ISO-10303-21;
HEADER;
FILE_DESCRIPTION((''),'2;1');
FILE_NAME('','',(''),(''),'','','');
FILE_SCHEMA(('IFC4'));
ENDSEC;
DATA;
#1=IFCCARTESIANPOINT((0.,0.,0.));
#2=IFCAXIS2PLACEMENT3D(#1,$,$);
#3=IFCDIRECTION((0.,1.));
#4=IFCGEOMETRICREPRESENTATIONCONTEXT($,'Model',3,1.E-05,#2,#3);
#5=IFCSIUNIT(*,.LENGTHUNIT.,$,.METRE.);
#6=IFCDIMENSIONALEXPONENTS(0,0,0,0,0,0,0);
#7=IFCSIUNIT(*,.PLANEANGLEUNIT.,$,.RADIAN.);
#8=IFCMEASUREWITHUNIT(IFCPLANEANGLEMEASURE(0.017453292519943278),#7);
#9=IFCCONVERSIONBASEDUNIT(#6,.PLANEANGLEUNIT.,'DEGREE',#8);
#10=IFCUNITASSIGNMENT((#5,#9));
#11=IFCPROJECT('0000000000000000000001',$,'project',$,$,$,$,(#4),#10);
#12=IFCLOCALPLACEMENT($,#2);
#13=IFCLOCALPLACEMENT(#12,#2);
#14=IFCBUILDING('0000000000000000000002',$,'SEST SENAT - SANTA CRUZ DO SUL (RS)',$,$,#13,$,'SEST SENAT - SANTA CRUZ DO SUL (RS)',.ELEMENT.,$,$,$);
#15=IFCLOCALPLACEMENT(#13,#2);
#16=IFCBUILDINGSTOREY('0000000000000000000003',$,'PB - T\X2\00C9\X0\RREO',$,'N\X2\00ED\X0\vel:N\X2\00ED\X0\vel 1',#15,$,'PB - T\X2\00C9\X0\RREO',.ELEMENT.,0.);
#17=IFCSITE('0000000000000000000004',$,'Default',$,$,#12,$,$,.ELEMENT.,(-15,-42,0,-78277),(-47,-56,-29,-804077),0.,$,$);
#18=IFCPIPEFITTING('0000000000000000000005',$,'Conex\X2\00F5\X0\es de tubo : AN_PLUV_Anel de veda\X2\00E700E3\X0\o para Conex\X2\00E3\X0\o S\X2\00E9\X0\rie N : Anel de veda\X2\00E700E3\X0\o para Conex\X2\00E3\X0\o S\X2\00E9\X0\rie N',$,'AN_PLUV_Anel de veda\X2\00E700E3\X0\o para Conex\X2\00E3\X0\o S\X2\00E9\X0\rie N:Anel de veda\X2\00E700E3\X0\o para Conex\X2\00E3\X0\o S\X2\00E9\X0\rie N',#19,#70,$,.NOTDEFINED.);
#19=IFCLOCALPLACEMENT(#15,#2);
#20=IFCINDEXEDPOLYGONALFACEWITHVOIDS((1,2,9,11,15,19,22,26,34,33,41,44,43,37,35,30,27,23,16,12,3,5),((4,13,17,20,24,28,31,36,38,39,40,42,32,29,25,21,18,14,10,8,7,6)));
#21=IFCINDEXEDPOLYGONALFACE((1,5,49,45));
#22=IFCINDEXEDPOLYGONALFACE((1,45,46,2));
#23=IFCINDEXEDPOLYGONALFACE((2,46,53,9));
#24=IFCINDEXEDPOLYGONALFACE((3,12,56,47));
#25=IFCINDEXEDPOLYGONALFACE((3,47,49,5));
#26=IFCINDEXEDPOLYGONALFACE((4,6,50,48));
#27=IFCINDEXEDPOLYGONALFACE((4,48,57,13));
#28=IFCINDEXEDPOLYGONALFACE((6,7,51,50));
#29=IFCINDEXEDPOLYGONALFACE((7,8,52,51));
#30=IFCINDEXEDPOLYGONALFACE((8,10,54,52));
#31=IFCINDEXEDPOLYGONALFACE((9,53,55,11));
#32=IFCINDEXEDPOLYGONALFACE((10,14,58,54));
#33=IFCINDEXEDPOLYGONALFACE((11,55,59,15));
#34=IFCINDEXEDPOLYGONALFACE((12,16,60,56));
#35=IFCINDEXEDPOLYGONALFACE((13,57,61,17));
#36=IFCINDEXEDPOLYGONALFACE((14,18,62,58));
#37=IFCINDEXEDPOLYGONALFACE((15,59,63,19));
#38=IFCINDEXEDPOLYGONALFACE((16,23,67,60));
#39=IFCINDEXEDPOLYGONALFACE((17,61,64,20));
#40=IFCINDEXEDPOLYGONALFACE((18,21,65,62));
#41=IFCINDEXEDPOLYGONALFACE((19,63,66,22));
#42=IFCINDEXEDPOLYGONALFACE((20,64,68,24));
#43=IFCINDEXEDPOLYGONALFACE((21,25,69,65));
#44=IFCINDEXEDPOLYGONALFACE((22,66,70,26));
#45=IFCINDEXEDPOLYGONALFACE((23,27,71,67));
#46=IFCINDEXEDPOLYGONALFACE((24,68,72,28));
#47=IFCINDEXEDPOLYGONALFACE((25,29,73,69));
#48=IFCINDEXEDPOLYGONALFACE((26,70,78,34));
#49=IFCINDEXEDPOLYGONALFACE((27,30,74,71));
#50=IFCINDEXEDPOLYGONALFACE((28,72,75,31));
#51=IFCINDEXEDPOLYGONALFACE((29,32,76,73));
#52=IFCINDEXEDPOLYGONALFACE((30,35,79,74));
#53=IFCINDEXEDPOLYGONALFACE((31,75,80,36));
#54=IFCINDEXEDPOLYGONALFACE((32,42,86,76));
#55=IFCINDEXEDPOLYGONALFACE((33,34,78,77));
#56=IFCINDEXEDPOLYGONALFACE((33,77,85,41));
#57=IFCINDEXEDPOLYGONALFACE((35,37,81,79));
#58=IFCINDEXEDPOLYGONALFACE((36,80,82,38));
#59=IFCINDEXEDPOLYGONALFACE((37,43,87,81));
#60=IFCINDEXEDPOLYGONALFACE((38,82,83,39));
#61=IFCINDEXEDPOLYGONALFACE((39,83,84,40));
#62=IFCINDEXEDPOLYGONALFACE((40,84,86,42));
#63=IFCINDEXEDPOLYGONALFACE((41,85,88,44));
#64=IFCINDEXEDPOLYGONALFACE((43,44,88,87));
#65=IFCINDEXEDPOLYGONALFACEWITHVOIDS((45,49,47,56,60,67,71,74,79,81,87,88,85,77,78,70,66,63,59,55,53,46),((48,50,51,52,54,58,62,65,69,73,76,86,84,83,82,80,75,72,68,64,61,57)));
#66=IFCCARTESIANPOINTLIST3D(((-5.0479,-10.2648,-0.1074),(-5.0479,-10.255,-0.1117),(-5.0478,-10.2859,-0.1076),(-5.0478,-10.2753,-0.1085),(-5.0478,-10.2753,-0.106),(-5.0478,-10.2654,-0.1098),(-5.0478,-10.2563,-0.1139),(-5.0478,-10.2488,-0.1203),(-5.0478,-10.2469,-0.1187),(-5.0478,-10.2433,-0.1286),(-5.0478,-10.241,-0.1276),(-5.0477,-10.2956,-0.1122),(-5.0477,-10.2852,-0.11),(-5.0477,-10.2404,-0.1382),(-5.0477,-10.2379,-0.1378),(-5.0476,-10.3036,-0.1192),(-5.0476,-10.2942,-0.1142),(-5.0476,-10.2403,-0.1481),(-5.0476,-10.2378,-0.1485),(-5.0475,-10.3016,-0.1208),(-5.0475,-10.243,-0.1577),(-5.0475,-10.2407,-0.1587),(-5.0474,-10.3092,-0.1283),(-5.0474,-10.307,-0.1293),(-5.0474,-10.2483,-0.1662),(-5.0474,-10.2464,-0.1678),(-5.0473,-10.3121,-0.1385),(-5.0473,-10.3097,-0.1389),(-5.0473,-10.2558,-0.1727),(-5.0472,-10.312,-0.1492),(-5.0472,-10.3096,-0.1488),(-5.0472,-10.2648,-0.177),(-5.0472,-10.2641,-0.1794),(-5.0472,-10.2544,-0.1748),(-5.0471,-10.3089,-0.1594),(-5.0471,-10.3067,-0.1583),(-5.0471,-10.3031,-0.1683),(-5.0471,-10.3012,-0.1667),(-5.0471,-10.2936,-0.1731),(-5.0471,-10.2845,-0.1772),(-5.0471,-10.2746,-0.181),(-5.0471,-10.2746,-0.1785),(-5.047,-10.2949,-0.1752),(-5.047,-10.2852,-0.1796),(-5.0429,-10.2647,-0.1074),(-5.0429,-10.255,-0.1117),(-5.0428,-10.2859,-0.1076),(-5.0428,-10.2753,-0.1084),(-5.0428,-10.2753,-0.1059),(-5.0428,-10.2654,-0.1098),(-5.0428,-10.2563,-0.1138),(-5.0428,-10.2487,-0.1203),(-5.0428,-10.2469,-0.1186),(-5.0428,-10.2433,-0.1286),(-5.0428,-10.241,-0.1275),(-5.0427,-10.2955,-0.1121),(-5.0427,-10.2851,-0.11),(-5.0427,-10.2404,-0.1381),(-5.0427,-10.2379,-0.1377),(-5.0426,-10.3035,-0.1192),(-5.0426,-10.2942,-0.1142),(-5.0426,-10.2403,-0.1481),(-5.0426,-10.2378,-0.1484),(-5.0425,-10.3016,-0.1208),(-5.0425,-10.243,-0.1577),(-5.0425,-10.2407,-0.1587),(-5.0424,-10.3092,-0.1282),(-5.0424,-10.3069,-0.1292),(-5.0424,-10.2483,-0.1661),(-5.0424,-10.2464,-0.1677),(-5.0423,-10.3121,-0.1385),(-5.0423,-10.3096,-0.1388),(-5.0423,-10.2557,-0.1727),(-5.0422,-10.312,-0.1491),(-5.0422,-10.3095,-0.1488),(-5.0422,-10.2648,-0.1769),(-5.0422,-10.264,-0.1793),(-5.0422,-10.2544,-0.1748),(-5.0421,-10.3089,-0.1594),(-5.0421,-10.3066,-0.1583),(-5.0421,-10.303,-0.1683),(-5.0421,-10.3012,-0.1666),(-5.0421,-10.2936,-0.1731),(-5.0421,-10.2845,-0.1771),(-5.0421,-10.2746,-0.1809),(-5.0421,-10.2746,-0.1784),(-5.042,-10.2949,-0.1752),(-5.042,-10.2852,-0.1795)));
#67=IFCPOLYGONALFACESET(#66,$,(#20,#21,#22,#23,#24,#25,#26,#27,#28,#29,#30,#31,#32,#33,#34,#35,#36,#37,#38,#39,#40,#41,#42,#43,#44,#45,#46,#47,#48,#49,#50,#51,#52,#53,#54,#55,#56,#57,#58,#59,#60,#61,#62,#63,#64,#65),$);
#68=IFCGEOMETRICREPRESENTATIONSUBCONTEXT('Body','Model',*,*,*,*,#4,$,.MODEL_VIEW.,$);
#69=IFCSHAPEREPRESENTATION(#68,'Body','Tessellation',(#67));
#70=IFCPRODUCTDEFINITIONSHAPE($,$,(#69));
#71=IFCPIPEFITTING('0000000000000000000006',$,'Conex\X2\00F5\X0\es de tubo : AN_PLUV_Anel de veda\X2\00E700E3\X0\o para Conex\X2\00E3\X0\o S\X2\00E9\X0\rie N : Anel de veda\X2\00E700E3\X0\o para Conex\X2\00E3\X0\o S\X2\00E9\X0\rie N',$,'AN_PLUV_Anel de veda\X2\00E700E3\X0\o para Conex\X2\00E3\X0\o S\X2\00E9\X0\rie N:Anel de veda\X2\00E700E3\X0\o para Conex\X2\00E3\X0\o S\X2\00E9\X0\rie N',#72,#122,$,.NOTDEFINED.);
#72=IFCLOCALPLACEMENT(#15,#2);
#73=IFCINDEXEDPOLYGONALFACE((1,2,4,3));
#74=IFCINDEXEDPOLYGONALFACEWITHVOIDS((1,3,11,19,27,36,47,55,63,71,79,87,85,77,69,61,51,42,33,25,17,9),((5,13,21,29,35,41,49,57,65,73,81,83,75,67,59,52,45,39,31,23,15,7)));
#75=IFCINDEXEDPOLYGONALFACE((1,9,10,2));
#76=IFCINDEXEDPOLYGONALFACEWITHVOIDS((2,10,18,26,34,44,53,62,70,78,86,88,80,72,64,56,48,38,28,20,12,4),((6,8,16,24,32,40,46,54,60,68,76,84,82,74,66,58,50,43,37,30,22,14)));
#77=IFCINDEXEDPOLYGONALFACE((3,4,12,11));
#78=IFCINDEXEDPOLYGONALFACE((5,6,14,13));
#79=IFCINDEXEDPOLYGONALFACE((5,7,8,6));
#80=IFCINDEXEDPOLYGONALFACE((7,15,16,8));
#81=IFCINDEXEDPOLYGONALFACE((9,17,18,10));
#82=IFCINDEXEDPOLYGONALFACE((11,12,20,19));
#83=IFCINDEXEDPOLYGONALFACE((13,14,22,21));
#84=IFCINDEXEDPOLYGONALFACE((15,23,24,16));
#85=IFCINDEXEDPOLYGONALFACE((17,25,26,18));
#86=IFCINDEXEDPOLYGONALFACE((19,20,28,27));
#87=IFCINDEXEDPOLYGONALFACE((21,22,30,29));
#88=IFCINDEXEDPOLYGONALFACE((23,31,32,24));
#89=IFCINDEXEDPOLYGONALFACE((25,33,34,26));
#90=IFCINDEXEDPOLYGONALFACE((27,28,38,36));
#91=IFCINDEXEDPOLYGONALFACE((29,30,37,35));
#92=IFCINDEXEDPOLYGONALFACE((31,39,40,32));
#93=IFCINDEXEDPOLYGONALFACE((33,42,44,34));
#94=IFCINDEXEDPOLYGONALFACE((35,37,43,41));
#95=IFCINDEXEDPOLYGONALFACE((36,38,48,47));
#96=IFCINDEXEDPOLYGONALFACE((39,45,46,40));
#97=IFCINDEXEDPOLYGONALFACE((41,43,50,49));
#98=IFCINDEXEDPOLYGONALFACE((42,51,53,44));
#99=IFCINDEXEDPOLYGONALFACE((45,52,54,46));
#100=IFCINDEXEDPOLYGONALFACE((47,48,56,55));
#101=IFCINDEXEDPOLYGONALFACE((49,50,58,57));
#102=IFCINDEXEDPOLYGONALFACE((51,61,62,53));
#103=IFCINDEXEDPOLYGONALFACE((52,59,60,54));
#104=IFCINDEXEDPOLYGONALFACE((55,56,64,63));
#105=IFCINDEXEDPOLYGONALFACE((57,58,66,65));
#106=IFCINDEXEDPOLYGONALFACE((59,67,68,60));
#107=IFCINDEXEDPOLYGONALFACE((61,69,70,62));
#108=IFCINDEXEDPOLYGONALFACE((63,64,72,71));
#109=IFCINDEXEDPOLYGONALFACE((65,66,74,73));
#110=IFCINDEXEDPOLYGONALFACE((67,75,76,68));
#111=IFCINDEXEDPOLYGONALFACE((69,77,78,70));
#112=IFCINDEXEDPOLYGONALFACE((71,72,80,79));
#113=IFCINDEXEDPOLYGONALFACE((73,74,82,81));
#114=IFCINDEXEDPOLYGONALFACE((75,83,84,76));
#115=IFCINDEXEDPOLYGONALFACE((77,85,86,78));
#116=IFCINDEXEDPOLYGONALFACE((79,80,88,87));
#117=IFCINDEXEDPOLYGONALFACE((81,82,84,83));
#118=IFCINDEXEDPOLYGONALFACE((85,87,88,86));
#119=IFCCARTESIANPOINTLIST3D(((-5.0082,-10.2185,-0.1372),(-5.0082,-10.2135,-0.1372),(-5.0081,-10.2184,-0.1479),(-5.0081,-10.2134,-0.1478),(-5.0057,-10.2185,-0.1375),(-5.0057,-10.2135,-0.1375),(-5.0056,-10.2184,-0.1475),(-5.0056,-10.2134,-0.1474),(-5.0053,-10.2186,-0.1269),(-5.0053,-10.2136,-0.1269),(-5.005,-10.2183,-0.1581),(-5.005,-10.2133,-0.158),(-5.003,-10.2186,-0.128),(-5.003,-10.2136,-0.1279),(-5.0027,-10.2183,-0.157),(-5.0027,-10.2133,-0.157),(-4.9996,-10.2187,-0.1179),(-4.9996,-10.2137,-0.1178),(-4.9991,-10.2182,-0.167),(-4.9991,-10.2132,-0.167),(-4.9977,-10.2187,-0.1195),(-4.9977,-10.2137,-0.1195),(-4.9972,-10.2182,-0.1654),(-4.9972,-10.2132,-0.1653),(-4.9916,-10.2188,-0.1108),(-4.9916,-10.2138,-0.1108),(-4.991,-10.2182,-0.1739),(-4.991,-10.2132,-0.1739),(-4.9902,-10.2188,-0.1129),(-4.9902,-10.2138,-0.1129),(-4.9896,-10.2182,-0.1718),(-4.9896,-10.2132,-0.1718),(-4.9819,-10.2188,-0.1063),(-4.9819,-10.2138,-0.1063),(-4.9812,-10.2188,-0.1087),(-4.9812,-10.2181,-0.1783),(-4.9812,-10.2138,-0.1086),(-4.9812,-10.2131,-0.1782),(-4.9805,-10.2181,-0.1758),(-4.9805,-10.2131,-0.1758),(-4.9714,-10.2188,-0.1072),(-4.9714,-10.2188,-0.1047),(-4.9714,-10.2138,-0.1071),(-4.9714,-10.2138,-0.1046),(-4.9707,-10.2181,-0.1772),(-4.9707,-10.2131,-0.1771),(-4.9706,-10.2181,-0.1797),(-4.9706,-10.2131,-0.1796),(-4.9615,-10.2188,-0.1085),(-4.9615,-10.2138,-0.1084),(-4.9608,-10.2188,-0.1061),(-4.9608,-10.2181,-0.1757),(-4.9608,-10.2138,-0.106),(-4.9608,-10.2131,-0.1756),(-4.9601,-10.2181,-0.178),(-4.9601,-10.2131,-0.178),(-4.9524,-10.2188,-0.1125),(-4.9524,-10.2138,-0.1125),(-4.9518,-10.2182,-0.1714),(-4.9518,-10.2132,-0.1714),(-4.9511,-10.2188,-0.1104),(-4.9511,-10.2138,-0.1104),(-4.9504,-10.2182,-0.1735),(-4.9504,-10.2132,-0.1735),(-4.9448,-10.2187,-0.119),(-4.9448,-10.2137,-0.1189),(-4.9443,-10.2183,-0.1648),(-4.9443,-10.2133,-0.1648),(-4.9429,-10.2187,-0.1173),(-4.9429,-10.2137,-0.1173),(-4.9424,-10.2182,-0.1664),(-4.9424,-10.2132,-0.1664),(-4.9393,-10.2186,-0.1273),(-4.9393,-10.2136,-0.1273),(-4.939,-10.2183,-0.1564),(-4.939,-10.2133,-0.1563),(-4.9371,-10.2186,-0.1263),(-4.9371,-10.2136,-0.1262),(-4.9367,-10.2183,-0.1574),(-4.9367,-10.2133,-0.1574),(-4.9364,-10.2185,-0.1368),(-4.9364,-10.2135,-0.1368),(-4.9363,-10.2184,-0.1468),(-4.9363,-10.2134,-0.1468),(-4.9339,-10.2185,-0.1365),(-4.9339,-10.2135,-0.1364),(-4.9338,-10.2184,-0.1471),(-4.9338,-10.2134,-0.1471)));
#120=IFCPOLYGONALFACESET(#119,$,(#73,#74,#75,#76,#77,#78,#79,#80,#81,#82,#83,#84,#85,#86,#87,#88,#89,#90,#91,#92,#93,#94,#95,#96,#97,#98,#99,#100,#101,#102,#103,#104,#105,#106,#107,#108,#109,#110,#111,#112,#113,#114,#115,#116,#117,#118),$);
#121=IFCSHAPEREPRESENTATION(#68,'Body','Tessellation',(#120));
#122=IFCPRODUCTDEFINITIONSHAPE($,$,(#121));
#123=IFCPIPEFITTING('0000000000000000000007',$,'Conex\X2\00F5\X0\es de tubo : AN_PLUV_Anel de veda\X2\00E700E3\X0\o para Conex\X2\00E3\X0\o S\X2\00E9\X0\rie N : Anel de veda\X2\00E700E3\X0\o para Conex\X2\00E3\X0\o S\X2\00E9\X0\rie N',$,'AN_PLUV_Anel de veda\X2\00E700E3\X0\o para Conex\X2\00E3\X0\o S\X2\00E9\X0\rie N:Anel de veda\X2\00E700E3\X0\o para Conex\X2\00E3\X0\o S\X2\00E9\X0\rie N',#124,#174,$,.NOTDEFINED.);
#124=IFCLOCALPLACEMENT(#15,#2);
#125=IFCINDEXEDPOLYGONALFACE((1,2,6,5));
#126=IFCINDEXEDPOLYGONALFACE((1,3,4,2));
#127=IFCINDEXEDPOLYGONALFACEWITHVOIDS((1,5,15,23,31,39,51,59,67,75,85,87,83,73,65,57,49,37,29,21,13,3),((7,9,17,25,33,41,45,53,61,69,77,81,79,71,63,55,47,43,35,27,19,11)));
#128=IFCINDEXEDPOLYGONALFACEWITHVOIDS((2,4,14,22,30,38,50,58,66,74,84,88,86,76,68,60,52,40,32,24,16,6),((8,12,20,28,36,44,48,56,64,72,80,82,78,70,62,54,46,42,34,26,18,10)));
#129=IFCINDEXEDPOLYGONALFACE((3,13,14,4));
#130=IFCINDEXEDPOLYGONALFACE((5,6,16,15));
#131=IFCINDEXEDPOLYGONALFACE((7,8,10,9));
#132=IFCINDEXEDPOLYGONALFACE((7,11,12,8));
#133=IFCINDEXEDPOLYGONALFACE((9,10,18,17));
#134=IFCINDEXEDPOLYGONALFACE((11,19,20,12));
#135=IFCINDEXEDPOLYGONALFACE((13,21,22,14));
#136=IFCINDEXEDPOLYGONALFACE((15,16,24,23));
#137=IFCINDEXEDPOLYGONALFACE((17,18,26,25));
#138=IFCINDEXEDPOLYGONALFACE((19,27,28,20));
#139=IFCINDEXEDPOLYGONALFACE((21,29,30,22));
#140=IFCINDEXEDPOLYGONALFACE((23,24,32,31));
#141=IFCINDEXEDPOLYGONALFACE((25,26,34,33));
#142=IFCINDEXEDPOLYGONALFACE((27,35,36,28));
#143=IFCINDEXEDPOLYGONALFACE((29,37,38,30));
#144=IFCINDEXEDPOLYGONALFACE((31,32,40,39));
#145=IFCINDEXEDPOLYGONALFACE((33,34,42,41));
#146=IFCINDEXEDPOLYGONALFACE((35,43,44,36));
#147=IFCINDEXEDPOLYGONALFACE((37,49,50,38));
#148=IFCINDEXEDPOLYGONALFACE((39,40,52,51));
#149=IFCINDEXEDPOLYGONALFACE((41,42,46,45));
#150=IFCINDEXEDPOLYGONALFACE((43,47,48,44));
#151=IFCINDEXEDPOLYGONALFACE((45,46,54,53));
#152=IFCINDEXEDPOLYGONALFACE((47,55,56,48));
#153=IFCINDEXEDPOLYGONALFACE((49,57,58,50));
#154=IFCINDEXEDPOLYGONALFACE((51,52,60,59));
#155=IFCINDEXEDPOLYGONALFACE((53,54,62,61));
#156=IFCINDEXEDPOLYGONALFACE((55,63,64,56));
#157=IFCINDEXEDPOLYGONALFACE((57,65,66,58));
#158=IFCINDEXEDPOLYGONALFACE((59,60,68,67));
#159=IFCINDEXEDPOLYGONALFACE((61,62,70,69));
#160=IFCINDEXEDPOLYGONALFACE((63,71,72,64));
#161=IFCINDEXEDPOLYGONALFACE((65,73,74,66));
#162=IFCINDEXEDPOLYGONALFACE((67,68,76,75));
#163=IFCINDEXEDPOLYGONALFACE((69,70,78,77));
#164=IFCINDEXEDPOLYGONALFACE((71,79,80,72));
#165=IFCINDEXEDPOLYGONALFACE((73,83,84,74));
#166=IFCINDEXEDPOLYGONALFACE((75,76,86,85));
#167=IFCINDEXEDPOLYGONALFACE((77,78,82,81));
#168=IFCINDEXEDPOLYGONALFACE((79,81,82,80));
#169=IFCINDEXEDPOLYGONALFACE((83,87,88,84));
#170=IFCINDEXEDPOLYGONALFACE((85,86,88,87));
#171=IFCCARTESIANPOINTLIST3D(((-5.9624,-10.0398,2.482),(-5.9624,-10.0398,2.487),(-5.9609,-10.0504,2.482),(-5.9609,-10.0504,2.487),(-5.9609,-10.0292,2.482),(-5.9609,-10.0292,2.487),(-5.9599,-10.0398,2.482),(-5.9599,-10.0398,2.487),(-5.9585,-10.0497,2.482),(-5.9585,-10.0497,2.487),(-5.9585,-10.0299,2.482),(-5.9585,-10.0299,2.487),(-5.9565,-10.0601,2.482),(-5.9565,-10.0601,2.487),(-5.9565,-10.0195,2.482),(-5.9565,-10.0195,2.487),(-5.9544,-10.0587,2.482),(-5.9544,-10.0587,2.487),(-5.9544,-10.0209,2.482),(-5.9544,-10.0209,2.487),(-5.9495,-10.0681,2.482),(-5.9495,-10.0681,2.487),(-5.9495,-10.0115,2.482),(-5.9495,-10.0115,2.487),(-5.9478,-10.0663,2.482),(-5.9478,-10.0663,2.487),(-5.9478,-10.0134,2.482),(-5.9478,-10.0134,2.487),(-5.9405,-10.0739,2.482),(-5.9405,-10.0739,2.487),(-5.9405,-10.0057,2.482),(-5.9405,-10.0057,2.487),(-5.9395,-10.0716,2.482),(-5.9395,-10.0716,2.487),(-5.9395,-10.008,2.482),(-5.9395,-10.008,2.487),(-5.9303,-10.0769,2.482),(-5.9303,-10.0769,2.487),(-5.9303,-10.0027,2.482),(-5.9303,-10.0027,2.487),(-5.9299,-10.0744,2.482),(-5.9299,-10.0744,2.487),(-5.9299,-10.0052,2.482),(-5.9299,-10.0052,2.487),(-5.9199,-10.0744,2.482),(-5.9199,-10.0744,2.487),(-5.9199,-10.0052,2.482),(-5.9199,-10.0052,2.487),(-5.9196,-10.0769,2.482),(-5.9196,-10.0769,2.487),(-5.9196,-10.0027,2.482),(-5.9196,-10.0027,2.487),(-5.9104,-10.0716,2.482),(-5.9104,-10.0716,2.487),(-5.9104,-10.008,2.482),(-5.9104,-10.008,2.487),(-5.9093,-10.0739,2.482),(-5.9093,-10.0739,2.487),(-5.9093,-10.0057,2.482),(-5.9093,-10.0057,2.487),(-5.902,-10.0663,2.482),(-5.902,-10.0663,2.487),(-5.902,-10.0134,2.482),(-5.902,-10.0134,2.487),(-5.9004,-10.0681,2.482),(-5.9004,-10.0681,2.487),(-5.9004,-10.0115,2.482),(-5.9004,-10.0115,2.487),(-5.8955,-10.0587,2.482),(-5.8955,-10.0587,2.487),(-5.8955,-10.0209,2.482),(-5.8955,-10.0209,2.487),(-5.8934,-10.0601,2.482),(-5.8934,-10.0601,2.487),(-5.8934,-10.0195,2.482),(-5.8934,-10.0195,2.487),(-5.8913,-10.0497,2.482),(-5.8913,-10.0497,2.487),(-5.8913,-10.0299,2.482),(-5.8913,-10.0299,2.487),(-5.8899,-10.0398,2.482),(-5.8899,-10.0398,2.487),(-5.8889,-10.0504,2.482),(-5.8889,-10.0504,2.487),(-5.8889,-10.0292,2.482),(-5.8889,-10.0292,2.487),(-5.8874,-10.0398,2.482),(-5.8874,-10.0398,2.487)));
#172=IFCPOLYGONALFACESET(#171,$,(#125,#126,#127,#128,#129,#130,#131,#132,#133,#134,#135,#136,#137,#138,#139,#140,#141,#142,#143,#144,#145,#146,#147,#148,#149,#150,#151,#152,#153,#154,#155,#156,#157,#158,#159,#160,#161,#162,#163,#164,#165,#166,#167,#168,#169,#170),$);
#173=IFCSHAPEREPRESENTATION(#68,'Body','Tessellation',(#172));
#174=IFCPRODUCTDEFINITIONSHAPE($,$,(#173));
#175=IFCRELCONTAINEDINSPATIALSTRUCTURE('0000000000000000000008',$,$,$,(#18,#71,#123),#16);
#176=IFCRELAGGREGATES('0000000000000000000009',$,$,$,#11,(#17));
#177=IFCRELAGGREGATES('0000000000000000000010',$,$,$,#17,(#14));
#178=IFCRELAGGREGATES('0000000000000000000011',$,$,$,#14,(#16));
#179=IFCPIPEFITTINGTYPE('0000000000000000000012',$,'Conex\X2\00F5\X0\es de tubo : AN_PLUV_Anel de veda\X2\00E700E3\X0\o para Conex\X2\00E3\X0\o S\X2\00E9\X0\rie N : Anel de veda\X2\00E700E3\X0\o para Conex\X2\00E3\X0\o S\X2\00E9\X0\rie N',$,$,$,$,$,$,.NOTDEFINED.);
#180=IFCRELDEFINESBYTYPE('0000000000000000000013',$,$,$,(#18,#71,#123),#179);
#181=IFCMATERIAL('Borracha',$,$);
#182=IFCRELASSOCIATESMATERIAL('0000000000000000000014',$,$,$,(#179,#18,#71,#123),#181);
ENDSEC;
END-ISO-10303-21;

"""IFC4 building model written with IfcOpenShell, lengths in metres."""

from ifc_helpers import new_model, entity, si_unit, converted_unit, direction, frame, origin, place, context, subcontext, project, spatial, arc, indexed_curve, outline, extrude, source, transform, mapped, material, type_object, type_shapes, element, save


model = new_model("IFC4")

# Units and contexts
model_context = context("Model", 3, precision=1e-05, world=origin(), true_north=direction((0.0, 1.0)))
body_context = subcontext(model_context, "Body", "Model", "MODEL_VIEW")
ifc_project = project(units=[si_unit("LENGTHUNIT", "METRE"), converted_unit("PLANEANGLEUNIT", "DEGREE", entity("IfcPlaneAngleMeasure", 0.017453292519943278), si_unit("PLANEANGLEUNIT", "RADIAN"), dimensions=[0, 0, 0, 0, 0, 0, 0])], contexts=[model_context])

# Site, building, storey
site_placement = place(None, origin())
site = spatial("IfcSite", under=ifc_project, at=site_placement, Name="Default", CompositionType="ELEMENT", RefLatitude=(-15, -42, 0, -78277), RefLongitude=(-47, -56, -29, -804077), RefElevation=0.0)
building_placement = place(site_placement, origin())
building = spatial("IfcBuilding", under=site, at=building_placement, Name="SEST SENAT - SANTA CRUZ DO SUL (RS)", LongName="SEST SENAT - SANTA CRUZ DO SUL (RS)", CompositionType="ELEMENT")
storey_placement = place(building_placement, origin())
storey = spatial("IfcBuildingStorey", under=building, at=storey_placement, Name="PB - TÉRREO", ObjectType="Nível:Nível 1", LongName="PB - TÉRREO", CompositionType="ELEMENT", Elevation=0.0)

# Pipe fittings
ifc_material_1 = material(Name="Borracha")
pipe_fitting_type = type_object("IfcPipeFittingType", Name="Conexões de tubo : AN_PLUV_Anel de vedação para Conexão Série N : Anel de vedação para Conexão Série N", PredefinedType="NOTDEFINED", material=ifc_material_1)
shared_shape_1 = source(origin(), body_context, "Body", "SweptSolid", [
    extrude(outline(indexed_curve([(-0.0375, 0.0), (0.0, -0.0375), (0.0375, 0.0), (0.0, 0.0375)], segments=[arc(1, 2, 3), arc(3, 4, 1)], self_intersect=False), holes=[indexed_curve([(-0.035, 0.0), (0.0, 0.035), (0.035, 0.0), (0.0, -0.035)], segments=[arc(1, 2, 3), arc(3, 4, 1)], self_intersect=False)]), frame((0.0, 0.0, -0.005)), (0.0, 0.0, 1.0), 0.005),
])
type_shapes(pipe_fitting_type, [shared_shape_1])
for number, where, z_axis, x_axis, name in (
    (1, (-5.0475, -10.275, -0.1435), (-0.999937, -0.005126, -0.010005), (-0.009954, -0.009925, 0.999901), "Conexões de tubo : AN_PLUV_Anel de vedação para Conexão Série N : Anel de vedação para Conexão Série N"),
    (2, (-4.971, -10.2185, -0.1422), (0.0, -0.999951, -0.009925), (-0.009954, -0.009925, 0.999901), "Conexões de tubo : AN_PLUV_Anel de vedação para Conexão Série N : Anel de vedação para Conexão Série N"),
    (3, (-5.9249, -10.0398, 2.482), (0.0, 0.0, -1.0), (-1.0, 0.0, 0.0), "Conexões de tubo : AN_PLUV_Anel de vedação para Conexão Série N : Anel de vedação para Conexão Série N"),
):
    element("IfcPipeFitting", number, at=place(storey_placement, frame(where, z_axis=z_axis, x_axis=x_axis)), inside=storey, type_object=pipe_fitting_type, material=ifc_material_1, Name=name, ObjectType="AN_PLUV_Anel de vedação para Conexão Série N:Anel de vedação para Conexão Série N", PredefinedType="NOTDEFINED", context=body_context, shape_type="MappedRepresentation", body=[
        mapped(shared_shape_1, transform((0.0, 0.0, 0.0), scale=1.0)),
    ])

save(model, "model.ifc")
